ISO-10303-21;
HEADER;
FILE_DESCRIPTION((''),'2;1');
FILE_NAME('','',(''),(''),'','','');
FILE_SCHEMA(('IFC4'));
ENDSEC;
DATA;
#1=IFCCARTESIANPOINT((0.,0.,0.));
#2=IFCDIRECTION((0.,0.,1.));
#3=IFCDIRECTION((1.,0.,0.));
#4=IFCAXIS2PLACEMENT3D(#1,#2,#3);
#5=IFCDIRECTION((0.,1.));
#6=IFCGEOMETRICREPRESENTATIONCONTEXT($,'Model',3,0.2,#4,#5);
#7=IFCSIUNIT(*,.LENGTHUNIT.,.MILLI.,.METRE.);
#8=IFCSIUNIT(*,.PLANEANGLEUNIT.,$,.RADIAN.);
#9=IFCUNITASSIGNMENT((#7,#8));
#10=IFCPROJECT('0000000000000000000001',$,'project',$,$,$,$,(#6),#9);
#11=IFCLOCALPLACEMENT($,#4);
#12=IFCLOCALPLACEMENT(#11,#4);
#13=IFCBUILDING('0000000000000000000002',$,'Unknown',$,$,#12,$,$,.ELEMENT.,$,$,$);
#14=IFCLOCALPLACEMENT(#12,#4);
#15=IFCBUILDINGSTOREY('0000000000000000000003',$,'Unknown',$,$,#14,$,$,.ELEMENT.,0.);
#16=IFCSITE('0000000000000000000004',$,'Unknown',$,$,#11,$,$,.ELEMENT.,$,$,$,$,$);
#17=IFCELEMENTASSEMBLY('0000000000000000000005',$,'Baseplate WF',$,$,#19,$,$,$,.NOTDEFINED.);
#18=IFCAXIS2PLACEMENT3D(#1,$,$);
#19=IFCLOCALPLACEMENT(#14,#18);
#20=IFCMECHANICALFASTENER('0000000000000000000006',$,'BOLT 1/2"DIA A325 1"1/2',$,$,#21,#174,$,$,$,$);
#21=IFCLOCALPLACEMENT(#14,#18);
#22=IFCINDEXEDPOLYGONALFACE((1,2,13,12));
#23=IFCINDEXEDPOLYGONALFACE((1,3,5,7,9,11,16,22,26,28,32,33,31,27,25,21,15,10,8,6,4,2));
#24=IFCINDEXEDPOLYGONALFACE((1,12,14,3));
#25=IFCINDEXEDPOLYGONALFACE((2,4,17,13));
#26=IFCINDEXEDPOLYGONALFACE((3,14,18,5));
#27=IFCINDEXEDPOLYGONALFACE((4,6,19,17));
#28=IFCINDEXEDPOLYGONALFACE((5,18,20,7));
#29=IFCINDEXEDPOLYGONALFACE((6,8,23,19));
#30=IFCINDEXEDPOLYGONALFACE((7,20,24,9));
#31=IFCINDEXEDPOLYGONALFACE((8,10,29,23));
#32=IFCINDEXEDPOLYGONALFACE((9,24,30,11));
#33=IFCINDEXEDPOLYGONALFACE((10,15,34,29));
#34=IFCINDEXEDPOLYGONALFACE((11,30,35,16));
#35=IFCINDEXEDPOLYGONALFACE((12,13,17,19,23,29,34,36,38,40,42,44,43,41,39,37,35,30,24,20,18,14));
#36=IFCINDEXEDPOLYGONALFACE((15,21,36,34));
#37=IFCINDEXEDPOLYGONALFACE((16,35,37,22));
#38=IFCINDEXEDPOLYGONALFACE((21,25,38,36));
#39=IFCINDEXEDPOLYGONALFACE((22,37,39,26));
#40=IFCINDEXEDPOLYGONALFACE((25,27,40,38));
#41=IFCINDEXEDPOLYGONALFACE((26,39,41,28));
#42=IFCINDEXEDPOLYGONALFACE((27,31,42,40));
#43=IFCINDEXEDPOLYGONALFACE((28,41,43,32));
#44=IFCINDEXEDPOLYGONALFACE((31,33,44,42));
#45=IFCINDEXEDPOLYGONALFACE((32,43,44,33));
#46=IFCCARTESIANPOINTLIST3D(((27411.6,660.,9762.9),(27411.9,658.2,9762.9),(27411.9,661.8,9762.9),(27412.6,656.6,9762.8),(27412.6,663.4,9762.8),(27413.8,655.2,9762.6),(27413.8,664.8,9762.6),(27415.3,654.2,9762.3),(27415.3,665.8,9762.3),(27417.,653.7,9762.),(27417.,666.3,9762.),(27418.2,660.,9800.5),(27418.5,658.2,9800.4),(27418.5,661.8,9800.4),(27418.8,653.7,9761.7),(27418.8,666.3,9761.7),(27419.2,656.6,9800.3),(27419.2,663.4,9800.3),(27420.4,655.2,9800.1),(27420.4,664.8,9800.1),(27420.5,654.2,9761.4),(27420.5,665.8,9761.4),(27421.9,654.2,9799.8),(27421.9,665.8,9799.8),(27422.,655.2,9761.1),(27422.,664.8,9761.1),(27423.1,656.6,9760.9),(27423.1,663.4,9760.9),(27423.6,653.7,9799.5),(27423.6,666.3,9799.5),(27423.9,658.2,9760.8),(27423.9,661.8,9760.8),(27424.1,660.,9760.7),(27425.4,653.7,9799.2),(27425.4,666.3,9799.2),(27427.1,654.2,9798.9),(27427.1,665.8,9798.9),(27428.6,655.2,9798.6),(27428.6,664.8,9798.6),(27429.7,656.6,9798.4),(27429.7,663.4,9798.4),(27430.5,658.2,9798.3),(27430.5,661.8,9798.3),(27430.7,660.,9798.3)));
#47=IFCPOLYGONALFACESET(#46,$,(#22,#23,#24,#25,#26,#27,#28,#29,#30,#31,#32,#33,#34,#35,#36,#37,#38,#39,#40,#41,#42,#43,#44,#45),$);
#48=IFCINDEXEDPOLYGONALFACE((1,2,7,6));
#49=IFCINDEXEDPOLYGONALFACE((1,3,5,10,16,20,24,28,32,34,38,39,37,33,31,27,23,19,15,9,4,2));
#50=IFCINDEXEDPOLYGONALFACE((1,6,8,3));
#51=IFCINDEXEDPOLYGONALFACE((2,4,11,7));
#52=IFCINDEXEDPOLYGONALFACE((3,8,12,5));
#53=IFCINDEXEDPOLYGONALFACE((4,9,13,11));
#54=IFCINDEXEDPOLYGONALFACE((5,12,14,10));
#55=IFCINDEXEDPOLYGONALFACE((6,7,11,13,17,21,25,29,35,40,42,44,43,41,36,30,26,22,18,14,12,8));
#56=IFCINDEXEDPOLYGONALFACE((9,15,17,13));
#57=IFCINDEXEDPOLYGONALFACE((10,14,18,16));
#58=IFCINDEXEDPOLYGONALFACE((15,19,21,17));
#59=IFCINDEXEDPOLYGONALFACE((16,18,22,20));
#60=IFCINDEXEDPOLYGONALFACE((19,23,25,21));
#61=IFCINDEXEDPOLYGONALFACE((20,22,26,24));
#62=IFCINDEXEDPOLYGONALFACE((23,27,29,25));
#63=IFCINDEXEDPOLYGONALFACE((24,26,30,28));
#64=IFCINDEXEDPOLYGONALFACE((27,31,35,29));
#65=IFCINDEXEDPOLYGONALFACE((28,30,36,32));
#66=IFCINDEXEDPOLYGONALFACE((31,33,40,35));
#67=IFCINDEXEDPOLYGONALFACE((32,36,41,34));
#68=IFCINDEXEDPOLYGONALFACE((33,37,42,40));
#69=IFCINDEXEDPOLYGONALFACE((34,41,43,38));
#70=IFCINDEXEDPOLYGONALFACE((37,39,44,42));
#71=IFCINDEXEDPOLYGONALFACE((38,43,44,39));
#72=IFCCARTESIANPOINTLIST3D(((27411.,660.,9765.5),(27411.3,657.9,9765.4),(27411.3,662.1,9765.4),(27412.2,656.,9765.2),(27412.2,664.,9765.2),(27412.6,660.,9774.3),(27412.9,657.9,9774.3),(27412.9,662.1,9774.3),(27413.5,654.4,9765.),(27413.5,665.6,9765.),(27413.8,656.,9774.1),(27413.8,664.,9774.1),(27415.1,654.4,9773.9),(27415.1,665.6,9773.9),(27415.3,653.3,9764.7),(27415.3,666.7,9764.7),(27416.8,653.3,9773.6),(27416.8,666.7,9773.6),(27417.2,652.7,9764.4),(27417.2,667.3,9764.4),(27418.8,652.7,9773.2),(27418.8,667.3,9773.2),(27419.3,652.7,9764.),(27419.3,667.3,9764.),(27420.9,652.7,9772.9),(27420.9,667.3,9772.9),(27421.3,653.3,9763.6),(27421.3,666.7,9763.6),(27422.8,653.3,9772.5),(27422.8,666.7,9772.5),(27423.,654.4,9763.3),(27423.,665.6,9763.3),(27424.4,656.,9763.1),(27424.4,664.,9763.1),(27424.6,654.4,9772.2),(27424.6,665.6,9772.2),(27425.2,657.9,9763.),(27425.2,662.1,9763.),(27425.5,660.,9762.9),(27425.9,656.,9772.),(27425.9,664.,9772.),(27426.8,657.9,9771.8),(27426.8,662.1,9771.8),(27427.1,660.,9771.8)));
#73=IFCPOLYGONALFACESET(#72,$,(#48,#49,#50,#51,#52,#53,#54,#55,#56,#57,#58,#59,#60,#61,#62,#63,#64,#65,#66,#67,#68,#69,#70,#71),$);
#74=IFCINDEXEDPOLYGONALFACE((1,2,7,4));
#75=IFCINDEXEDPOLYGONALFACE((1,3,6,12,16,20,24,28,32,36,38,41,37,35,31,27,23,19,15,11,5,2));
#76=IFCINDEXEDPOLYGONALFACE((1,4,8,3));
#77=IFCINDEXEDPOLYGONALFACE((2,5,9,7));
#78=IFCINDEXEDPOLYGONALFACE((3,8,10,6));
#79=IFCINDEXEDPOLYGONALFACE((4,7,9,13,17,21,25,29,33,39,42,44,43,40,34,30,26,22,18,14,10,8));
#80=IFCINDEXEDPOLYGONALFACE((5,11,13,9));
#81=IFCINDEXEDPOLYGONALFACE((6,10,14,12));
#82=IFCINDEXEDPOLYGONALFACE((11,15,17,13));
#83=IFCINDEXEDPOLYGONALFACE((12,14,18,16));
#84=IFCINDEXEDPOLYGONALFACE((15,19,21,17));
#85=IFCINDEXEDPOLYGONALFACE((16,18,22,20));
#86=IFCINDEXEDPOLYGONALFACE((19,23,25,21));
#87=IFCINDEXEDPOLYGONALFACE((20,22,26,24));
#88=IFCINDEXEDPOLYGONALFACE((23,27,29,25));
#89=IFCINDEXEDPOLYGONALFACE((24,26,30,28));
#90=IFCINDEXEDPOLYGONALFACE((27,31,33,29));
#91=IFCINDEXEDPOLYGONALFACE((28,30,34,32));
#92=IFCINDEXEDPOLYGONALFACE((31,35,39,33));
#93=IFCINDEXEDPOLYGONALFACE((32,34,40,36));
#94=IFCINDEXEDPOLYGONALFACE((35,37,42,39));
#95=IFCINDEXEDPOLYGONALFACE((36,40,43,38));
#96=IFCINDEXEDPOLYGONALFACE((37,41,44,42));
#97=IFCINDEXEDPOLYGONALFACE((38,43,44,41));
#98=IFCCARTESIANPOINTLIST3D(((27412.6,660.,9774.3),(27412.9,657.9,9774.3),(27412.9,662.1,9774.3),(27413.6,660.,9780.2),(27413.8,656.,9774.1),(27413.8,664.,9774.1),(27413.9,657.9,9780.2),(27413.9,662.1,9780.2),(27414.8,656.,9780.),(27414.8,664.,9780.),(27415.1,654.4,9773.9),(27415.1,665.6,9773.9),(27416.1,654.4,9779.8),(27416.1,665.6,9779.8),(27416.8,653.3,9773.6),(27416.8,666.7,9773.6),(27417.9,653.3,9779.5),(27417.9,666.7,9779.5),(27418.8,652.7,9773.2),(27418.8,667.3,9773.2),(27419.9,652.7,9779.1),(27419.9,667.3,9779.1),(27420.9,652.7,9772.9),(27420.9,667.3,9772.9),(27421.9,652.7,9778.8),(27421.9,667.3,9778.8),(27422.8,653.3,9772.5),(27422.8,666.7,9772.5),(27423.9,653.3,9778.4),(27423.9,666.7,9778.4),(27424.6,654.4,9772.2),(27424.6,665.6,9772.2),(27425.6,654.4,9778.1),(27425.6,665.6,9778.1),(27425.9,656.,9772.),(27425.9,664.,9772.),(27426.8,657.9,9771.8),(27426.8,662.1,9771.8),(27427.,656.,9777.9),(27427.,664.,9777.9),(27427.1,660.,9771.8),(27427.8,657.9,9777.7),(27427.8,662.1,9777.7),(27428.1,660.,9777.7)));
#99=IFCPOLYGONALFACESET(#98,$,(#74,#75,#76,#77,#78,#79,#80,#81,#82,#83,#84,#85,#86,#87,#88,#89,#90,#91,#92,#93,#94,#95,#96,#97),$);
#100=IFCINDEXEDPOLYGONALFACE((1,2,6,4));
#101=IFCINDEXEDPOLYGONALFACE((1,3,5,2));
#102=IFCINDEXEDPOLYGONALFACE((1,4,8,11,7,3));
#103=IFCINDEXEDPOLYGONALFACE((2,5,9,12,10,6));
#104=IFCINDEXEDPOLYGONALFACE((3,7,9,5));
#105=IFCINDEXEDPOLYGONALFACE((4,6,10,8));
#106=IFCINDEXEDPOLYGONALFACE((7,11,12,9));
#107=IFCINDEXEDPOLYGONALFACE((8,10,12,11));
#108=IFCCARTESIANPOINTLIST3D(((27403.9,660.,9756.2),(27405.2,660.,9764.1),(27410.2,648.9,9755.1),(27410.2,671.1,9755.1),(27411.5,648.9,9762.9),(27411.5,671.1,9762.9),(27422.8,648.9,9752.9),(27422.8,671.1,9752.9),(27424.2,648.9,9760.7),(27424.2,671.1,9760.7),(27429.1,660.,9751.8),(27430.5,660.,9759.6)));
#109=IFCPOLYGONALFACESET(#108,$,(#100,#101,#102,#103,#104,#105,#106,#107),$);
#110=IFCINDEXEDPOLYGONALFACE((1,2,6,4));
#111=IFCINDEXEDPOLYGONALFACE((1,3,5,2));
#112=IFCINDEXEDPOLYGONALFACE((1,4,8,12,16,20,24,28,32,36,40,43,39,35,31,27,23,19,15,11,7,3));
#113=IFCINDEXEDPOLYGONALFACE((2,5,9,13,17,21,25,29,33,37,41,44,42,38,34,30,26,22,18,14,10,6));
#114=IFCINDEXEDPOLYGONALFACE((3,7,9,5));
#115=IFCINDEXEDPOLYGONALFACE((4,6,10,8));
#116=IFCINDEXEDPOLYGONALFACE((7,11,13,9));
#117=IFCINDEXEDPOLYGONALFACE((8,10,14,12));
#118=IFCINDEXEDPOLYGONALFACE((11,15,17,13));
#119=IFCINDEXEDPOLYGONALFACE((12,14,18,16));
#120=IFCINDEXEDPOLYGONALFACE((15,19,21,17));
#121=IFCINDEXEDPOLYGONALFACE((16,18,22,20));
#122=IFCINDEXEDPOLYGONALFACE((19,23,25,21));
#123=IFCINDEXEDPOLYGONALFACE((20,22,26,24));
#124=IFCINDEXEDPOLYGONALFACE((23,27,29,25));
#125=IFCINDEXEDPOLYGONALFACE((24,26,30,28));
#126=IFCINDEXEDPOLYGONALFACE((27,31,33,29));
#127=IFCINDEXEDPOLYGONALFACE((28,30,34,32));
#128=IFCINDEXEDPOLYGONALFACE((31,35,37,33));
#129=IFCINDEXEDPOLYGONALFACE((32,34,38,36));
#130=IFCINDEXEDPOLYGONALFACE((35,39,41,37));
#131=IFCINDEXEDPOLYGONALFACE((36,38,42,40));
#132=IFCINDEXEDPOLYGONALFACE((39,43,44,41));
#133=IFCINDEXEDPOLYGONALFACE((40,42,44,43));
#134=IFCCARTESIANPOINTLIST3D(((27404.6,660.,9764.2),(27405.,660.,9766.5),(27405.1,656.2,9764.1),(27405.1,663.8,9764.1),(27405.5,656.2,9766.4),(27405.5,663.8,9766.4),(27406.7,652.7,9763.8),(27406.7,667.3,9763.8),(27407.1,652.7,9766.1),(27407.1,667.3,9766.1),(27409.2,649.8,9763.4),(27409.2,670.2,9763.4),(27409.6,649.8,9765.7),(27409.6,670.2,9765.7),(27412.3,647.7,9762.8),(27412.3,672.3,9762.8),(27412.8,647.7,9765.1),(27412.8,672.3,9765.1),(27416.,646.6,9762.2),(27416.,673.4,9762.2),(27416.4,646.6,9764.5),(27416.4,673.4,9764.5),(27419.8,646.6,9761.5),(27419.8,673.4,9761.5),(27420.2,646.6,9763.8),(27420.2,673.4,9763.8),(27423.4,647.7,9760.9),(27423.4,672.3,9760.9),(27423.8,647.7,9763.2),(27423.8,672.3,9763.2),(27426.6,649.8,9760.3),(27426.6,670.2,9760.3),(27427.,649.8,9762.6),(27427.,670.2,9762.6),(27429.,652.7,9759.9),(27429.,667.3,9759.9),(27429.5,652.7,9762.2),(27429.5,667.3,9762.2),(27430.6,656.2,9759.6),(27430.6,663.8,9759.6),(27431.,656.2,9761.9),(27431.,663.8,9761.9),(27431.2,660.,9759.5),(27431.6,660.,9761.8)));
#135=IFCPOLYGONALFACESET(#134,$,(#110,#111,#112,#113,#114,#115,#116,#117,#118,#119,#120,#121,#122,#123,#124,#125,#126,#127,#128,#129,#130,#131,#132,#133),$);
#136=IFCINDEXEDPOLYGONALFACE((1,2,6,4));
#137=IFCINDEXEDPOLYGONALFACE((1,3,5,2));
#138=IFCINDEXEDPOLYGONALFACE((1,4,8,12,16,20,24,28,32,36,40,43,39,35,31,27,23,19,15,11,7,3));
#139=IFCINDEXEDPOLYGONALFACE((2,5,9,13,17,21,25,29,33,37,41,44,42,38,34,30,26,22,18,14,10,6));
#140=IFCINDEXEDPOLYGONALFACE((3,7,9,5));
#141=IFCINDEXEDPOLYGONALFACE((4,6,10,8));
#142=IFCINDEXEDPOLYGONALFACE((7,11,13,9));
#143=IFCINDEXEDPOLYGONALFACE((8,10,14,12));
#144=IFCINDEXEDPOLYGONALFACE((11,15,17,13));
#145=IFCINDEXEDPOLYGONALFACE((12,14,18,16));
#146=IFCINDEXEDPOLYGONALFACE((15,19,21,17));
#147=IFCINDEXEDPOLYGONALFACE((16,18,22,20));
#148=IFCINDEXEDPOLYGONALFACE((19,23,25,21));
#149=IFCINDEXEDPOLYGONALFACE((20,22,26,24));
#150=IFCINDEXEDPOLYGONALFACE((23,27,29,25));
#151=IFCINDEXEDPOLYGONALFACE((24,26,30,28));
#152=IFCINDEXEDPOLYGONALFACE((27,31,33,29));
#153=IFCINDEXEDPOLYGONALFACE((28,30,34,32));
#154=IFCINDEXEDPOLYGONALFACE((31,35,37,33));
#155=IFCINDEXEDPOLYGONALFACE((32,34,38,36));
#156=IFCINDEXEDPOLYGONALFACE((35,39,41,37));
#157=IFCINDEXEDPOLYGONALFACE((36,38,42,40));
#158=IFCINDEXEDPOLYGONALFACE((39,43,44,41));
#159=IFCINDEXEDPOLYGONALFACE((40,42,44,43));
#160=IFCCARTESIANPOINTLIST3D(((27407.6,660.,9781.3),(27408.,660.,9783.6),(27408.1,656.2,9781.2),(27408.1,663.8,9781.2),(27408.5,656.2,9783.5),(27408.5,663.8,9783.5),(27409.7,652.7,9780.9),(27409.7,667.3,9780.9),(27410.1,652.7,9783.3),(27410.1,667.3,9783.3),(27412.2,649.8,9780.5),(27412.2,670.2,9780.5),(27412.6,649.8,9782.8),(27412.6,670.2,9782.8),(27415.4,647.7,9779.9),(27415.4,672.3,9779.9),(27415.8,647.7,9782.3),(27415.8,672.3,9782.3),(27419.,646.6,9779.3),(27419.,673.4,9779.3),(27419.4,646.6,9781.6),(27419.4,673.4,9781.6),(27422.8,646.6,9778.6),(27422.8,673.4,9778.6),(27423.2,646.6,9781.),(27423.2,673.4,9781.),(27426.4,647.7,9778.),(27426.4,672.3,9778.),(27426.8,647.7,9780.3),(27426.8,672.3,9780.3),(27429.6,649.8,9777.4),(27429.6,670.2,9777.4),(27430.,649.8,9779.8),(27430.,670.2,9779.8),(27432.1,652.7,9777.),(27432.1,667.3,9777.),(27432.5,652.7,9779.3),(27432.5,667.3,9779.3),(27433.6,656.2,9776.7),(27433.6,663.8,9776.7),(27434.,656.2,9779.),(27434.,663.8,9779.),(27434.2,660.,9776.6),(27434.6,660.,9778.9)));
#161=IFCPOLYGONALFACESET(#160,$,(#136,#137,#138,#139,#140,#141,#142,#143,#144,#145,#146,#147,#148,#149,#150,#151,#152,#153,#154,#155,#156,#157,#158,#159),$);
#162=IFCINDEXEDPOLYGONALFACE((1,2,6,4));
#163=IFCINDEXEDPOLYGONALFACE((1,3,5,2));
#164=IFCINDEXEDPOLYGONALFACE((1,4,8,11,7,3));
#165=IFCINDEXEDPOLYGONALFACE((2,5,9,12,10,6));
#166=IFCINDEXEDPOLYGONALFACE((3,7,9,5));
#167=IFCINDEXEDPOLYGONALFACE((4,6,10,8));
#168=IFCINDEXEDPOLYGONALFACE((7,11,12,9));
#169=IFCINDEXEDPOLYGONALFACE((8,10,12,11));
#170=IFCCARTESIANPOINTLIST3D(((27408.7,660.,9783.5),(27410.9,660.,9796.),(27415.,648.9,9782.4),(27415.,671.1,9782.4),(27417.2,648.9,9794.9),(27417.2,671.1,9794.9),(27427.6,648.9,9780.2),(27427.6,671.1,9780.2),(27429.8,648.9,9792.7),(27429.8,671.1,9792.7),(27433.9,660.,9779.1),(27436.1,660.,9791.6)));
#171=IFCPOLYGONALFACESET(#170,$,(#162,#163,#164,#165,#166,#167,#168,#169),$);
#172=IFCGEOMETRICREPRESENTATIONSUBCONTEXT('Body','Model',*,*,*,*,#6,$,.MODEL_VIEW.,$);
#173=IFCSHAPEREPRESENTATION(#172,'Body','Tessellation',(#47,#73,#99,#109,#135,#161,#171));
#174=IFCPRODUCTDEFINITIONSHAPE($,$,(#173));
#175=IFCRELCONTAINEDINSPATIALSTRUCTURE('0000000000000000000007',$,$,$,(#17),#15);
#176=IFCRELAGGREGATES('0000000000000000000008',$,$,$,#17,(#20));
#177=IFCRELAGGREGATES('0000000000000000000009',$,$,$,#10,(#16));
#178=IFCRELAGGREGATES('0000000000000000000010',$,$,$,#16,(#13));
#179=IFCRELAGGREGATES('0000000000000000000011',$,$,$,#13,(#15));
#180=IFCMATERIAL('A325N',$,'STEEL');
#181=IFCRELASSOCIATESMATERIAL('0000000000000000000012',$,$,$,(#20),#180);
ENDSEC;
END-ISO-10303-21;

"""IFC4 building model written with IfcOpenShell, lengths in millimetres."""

from ifc_helpers import new_model, si_unit, direction, frame, origin_with_axes, place, context, subcontext, project, spatial, line, arc, indexed_curve, outline, extrude, source, transform, mapped, material, element, aggregate, save


model = new_model("IFC4")

# Units and contexts
model_context = context("Model", 3, precision=0.2, world=origin_with_axes(), true_north=direction((0.0, 1.0)))
body_context = subcontext(model_context, "Body", "Model", "MODEL_VIEW")
ifc_project = project(units=[si_unit("LENGTHUNIT", "METRE", prefix="MILLI"), si_unit("PLANEANGLEUNIT", "RADIAN")], contexts=[model_context])

# Site, building, storey
site_placement = place(None, origin_with_axes())
site = spatial("IfcSite", under=ifc_project, at=site_placement, Name="Unknown", CompositionType="ELEMENT")
building_placement = place(site_placement, origin_with_axes())
building = spatial("IfcBuilding", under=site, at=building_placement, Name="Unknown", CompositionType="ELEMENT")
storey_placement = place(building_placement, origin_with_axes())
storey = spatial("IfcBuildingStorey", under=building, at=storey_placement, Name="Unknown", CompositionType="ELEMENT", Elevation=0.0)

# Element assembly
assembly_1_placement = place(storey_placement, frame((27449.9, 690.0, 9770.8), z_axis=(-0.173648, 0.0, -0.984808), x_axis=(0.0, -1.0, 0.0)))
assembly_1 = element("IfcElementAssembly", 1, at=assembly_1_placement, inside=storey, Name="Baseplate WF", PredefinedType="NOTDEFINED")

# Mechanical fastener
ifc_material_1 = material(Name="A325N", Category="STEEL")
shared_shape = source(origin_with_axes(), body_context, "Body", "SweptSolid", [
    extrude(outline(indexed_curve([(6.3, 0.0), (0.0, 6.3), (-6.3, 0.0), (0.0, -6.3)], segments=[arc(1, 2, 3), arc(3, 4, 1)])), frame((0.0, 0.0, 17.4), z_axis=(0.0, 0.0, -1.0), x_axis=(0.0, 1.0, 0.0)), (0.0, 0.0, 1.0), 38.1),
    extrude(outline(indexed_curve([(7.3, 0.0), (0.0, 7.3), (-7.3, 0.0), (0.0, -7.3)], segments=[arc(1, 2, 3), arc(3, 4, 1)])), frame((0.0, 0.0, 15.0), z_axis=(0.0, 0.0, -1.0), x_axis=(0.0, 1.0, 0.0)), (0.0, 0.0, 1.0), 9.0),
    extrude(outline(indexed_curve([(7.3, 0.0), (0.0, 7.3), (-7.3, 0.0), (0.0, -7.3)], segments=[arc(1, 2, 3), arc(3, 4, 1)])), frame((0.0, 0.0, 6.0), z_axis=(0.0, 0.0, -1.0), x_axis=(0.0, 1.0, 0.0)), (0.0, 0.0, 1.0), 6.0),
    extrude(outline(indexed_curve([(12.8, 0.0), (6.4, 11.1), (-6.4, 11.1), (-12.8, 0.0), (-6.4, -11.1), (6.4, -11.1)], segments=[line(1, 2, 3, 4, 5, 6, 1)])), frame((0.0, 0.0, 25.3), z_axis=(0.0, 0.0, -1.0), x_axis=(0.0, 1.0, 0.0)), (0.0, 0.0, 1.0), 7.9),
    extrude(outline(indexed_curve([(13.5, 0.0), (0.0, 13.5), (-13.5, 0.0), (0.0, -13.5)], segments=[arc(1, 2, 3), arc(3, 4, 1)])), frame((0.0, 0.0, 17.4), z_axis=(0.0, 0.0, -1.0), x_axis=(0.0, 1.0, 0.0)), (0.0, 0.0, 1.0), 2.4),
    extrude(outline(indexed_curve([(13.5, 0.0), (0.0, 13.5), (-13.5, 0.0), (0.0, -13.5)], segments=[arc(1, 2, 3), arc(3, 4, 1)])), frame((0.0, 0.0, 0.0), z_axis=(0.0, 0.0, -1.0), x_axis=(0.0, 1.0, 0.0)), (0.0, 0.0, 1.0), 2.4),
    extrude(outline(indexed_curve([(12.8, 0.0), (6.4, 11.1), (-6.4, 11.1), (-12.8, 0.0), (-6.4, -11.1), (6.4, -11.1)], segments=[line(1, 2, 3, 4, 5, 6, 1)])), frame((0.0, 0.0, -2.4), z_axis=(0.0, 0.0, -1.0), x_axis=(0.0, 1.0, 0.0)), (0.0, 0.0, 1.0), 12.7),
])
mechanical_fastener_1_placement = place(assembly_1_placement, frame((30.0, 30.0, -3.0), z_axis=(0.0, 0.0, 1.0), x_axis=(-1.0, 0.0, 0.0)))
mechanical_fastener_1 = element("IfcMechanicalFastener", 2, at=mechanical_fastener_1_placement, material=ifc_material_1, Name="BOLT 1/2\"DIA A325 1\"1/2", context=body_context, shape_type="MappedRepresentation", body=[
    mapped(shared_shape, transform((0.0, 0.0, 0.0))),
])
aggregate(assembly_1, [mechanical_fastener_1])

save(model, "model.ifc")
